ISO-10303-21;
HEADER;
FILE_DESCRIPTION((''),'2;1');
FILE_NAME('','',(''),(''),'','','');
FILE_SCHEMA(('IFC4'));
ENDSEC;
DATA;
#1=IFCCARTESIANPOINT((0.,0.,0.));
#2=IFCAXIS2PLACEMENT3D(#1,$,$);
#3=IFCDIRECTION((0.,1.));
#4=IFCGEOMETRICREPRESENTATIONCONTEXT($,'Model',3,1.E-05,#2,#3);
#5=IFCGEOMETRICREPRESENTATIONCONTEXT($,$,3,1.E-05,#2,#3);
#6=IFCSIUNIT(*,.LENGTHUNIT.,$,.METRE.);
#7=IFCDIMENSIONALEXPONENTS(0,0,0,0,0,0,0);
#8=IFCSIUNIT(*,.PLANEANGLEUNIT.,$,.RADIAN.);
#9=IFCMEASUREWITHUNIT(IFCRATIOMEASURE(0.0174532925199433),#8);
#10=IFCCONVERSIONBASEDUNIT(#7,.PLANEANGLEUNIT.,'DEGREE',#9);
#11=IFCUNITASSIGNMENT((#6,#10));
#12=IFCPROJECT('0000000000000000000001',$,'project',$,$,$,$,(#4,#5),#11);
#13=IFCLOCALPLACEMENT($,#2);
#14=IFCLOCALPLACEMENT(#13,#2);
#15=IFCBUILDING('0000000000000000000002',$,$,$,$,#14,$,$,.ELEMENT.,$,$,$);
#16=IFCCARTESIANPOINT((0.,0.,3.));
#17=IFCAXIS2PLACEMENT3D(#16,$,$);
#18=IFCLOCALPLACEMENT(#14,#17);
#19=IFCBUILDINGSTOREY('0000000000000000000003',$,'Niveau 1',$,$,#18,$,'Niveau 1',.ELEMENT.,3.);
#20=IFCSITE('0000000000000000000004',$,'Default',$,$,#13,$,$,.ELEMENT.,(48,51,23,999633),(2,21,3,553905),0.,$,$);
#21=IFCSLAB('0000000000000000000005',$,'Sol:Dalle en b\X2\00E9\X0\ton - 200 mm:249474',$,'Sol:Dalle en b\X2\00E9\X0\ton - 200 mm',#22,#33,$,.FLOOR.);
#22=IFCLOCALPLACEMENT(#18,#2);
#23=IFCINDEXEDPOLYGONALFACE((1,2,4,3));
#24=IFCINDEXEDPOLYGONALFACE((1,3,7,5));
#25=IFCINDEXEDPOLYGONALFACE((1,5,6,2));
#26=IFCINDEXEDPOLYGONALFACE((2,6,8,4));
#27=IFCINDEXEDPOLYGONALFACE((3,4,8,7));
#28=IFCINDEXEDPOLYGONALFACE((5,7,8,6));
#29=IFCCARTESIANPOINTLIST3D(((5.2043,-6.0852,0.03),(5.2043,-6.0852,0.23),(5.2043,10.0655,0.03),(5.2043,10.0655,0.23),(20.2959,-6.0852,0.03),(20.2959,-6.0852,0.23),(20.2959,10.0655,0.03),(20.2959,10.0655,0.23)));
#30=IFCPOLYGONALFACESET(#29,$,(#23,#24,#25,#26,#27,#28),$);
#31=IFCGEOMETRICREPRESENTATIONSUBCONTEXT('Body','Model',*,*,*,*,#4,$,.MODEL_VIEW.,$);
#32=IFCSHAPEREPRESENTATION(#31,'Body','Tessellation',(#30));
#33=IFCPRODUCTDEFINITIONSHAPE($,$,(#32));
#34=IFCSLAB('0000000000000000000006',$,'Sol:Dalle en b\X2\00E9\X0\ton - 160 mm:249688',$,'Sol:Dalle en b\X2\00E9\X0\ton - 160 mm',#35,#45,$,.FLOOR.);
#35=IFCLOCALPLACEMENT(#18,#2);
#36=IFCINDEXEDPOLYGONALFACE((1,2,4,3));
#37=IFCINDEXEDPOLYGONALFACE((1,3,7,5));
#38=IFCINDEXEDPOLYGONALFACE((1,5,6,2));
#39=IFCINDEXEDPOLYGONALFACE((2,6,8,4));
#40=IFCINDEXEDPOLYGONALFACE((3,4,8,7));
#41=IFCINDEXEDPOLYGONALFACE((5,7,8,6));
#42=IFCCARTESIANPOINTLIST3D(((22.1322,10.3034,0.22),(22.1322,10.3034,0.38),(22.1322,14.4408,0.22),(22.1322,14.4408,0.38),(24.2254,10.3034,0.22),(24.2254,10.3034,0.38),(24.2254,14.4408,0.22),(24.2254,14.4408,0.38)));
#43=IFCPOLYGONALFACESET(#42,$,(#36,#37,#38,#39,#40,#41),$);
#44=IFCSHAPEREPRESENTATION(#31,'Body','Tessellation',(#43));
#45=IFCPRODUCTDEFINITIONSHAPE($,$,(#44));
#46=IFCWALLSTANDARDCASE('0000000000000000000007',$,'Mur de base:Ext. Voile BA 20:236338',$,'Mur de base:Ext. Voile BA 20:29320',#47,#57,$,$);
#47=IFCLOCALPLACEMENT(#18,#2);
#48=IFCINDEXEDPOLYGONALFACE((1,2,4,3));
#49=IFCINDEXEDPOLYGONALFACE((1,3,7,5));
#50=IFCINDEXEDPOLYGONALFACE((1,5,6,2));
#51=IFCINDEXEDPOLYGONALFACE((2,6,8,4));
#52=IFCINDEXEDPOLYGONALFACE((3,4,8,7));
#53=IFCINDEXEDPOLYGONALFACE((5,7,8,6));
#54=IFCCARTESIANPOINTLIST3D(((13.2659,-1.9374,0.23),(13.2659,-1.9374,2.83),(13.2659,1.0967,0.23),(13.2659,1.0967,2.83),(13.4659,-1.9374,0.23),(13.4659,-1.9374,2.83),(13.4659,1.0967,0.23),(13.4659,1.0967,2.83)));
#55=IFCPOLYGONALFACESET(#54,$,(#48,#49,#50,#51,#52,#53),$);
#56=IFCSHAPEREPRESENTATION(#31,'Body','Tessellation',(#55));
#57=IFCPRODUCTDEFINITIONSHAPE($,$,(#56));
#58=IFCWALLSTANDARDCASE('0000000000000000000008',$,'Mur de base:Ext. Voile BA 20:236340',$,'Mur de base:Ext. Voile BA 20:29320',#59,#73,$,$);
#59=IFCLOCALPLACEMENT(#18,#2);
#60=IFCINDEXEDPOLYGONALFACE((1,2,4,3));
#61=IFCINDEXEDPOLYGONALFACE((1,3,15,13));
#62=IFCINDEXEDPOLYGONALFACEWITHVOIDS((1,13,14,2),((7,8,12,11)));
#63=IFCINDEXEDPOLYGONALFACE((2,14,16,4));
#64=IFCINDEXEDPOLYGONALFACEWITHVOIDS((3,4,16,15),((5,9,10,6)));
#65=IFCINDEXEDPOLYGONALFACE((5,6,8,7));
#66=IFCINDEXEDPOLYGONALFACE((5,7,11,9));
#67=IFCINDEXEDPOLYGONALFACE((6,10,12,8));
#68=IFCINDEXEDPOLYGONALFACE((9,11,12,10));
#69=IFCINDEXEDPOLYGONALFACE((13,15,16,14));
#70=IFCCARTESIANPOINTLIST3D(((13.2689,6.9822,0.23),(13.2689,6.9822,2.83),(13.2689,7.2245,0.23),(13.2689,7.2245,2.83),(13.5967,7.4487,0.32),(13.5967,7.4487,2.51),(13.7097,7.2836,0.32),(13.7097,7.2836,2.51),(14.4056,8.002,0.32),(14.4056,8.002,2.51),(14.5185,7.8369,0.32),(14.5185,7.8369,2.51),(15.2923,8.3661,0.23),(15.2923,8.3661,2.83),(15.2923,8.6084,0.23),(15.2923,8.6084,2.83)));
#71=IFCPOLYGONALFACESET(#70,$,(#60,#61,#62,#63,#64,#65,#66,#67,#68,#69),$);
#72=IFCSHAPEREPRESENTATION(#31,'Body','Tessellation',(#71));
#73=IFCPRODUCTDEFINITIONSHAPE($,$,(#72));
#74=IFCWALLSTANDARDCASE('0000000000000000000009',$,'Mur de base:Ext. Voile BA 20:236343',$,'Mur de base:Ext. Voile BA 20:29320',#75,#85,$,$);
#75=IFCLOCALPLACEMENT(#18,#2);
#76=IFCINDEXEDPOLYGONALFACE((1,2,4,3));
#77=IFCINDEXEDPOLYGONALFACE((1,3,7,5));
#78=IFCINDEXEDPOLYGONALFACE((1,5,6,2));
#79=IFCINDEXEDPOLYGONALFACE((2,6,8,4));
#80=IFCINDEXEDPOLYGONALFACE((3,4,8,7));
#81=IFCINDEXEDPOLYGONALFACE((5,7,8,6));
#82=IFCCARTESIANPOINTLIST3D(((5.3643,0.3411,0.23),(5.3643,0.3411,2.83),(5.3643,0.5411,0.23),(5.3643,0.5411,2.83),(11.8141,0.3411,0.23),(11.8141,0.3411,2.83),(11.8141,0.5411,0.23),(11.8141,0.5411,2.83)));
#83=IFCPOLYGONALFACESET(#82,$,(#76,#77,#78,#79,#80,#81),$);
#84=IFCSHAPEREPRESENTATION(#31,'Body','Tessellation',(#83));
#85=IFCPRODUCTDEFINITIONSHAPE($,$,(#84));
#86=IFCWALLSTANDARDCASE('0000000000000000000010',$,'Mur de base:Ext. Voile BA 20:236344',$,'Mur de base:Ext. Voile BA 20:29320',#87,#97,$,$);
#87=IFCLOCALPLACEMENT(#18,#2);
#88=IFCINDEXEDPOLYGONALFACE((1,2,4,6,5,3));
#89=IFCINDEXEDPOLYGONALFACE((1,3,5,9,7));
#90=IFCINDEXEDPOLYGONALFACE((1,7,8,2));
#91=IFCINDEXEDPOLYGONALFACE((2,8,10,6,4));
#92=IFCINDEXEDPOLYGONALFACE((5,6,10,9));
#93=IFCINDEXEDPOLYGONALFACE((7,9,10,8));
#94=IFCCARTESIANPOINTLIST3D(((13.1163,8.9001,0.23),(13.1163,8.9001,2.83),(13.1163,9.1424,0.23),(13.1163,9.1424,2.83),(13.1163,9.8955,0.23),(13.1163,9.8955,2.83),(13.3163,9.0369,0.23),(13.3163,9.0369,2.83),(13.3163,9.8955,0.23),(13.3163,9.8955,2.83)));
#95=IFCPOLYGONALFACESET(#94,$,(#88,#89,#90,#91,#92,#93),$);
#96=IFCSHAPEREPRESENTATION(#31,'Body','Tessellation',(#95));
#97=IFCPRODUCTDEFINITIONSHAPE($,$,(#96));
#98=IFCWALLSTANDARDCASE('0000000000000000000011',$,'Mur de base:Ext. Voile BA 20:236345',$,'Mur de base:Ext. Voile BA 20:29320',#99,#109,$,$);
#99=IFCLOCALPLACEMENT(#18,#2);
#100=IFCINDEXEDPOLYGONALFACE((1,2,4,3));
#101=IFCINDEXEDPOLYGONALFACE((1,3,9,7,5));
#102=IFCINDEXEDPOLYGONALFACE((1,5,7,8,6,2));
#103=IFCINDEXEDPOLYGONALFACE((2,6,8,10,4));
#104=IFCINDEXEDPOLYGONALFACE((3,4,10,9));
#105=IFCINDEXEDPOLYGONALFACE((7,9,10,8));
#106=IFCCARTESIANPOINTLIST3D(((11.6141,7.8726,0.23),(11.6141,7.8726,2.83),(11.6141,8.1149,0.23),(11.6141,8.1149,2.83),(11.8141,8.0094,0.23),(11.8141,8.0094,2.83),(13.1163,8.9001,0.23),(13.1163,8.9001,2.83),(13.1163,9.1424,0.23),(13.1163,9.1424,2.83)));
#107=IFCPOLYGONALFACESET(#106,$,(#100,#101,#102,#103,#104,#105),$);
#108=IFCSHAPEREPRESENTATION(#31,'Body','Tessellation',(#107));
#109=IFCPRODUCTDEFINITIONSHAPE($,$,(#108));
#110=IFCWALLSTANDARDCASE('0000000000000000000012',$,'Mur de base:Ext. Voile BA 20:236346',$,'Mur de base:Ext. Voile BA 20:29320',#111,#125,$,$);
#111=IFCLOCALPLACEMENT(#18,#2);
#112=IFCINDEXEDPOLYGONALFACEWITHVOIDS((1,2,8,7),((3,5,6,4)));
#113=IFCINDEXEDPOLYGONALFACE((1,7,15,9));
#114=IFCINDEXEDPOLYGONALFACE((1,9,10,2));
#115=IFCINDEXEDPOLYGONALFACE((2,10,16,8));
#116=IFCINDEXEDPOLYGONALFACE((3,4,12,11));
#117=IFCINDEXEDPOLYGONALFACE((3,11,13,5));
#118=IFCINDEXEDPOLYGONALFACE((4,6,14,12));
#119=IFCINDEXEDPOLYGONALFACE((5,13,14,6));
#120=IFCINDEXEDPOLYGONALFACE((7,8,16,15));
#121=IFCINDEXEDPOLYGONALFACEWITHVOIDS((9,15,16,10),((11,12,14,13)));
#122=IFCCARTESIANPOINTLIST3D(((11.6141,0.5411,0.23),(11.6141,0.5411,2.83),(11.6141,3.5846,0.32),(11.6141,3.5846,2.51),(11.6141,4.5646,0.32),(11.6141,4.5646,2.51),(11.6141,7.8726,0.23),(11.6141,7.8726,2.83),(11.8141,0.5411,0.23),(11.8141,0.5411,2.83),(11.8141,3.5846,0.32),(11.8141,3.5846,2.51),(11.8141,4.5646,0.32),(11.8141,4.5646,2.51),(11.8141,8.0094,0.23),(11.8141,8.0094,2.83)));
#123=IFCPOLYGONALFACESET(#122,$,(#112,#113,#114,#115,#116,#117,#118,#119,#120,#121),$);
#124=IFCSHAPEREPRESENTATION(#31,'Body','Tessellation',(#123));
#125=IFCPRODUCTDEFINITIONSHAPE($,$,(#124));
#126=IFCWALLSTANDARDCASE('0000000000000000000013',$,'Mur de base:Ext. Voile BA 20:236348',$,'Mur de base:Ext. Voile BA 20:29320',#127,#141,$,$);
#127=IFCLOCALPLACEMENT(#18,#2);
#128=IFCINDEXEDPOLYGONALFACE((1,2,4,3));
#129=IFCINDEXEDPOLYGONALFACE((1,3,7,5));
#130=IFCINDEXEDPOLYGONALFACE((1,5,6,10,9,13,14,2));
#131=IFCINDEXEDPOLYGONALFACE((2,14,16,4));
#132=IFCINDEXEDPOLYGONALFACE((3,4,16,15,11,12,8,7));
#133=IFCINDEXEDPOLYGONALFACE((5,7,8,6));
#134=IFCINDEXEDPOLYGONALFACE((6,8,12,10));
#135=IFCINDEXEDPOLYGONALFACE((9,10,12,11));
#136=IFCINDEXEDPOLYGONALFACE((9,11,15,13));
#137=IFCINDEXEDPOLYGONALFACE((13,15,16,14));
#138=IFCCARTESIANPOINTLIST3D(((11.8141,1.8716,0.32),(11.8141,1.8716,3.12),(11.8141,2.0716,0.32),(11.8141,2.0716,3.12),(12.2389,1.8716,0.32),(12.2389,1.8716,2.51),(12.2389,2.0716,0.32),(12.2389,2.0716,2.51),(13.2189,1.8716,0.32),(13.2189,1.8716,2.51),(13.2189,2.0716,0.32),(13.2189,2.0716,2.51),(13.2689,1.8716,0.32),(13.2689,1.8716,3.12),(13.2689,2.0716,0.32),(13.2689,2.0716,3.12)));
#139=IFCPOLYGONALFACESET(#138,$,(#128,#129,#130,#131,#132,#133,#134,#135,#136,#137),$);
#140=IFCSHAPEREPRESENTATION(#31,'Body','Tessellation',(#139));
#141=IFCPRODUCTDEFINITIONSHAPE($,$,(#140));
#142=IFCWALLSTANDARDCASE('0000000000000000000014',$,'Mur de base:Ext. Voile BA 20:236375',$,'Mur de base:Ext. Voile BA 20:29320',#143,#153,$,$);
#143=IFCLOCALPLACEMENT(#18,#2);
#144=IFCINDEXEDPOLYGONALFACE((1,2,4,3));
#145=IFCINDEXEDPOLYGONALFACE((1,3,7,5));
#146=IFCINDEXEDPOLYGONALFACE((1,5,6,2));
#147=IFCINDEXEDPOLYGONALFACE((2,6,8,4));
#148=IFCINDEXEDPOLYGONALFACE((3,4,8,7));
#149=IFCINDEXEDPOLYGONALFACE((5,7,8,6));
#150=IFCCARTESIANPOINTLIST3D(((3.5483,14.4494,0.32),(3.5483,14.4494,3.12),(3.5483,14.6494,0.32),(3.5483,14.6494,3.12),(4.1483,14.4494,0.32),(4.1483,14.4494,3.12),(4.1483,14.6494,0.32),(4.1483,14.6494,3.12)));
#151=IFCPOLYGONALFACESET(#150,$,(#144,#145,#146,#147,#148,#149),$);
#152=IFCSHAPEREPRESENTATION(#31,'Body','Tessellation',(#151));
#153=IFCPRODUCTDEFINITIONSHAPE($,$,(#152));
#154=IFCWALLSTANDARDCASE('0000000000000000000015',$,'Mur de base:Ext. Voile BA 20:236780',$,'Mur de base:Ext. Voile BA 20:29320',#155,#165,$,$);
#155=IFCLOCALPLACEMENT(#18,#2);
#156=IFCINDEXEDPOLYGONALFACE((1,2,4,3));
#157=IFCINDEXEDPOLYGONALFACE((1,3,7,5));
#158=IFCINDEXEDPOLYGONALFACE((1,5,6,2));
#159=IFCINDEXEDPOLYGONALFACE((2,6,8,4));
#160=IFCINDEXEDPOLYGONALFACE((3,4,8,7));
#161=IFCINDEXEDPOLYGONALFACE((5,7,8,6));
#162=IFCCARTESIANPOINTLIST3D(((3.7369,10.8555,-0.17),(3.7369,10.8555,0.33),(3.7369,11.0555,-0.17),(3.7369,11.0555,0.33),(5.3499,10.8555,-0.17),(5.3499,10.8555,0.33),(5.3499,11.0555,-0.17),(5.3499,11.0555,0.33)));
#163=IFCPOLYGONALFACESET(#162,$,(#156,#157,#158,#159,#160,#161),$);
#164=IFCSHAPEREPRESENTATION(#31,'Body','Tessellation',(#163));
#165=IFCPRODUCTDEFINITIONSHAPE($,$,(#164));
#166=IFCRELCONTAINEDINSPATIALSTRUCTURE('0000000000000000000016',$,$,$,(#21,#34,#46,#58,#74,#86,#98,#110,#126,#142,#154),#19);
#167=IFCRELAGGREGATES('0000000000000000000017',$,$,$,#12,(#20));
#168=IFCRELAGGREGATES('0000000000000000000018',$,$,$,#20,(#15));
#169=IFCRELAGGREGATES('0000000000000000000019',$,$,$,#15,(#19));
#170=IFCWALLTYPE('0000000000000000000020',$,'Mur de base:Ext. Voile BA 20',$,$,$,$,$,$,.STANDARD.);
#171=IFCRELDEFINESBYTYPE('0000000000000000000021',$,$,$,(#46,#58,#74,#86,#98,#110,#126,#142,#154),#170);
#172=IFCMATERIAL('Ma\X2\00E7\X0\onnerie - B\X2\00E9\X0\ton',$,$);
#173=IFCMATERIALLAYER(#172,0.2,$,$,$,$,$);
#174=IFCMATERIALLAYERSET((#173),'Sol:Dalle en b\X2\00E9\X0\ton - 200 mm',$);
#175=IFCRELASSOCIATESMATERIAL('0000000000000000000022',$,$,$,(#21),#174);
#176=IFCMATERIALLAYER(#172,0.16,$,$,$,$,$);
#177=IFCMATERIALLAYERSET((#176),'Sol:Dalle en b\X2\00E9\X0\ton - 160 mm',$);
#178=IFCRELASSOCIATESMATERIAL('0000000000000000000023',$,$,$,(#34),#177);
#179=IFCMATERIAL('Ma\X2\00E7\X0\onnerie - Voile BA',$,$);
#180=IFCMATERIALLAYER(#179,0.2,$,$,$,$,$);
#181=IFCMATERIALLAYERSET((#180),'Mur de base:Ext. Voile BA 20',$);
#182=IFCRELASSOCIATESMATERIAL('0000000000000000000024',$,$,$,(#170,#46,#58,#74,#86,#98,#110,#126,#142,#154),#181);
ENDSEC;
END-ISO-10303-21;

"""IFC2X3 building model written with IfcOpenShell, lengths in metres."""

from ifc_helpers import new_model, entity, si_unit, converted_unit, direction, frame, frame_2d, origin, origin_2d_with_axis, place, context, subcontext, project, spatial, polyline, rectangle, outline, extrude, material, layer, layer_set, layer_usage, type_object, element, save


model = new_model("IFC2X3")

# Units and contexts
model_context = context("Model", 3, precision=1e-05, world=origin(), true_north=direction((0.0, 1.0)))
context_of_model = context(None, 3, precision=1e-05, world=origin(), true_north=direction((0.0, 1.0)))
body_context = subcontext(model_context, "Body", "Model", "MODEL_VIEW")
ifc_project = project(units=[si_unit("LENGTHUNIT", "METRE"), converted_unit("PLANEANGLEUNIT", "DEGREE", entity("IfcRatioMeasure", 0.0174532925199433), si_unit("PLANEANGLEUNIT", "RADIAN"), dimensions=[0, 0, 0, 0, 0, 0, 0])], contexts=[model_context, context_of_model])

# Site, building, storey
site_placement = place(None, origin())
site = spatial("IfcSite", under=ifc_project, at=site_placement, Name="Default", CompositionType="ELEMENT", RefLatitude=(48, 51, 23, 999633), RefLongitude=(2, 21, 3, 553905), RefElevation=0.0)
building_placement = place(site_placement, origin())
building = spatial("IfcBuilding", under=site, at=building_placement, CompositionType="ELEMENT")
storey_placement = place(building_placement, frame((0.0, 0.0, 3.0)))
storey = spatial("IfcBuildingStorey", under=building, at=storey_placement, Name="Niveau 1", LongName="Niveau 1", CompositionType="ELEMENT", Elevation=3.0)

# Shared definitions
ifc_material_1 = material(Name="Maçonnerie - Béton")
ifc_layer_1 = layer(ifc_material_1, 0.2)
ifc_layer_set_1 = layer_set([ifc_layer_1], Name="Sol:Dalle en béton - 200 mm")

# Slabs
ifc_layer_usage_1 = layer_usage(ifc_layer_set_1, "AXIS3", "POSITIVE", 0.0)
slab_1_placement = place(storey_placement, origin())
element("IfcSlab", 1, at=slab_1_placement, inside=storey, material=ifc_layer_usage_1, Name="Sol:Dalle en béton - 200 mm:249474", ObjectType="Sol:Dalle en béton - 200 mm", PredefinedType="FLOOR", context=body_context, shape_type="SweptSolid", body=[
    extrude(rectangle(XDim=16.1506, YDim=15.0917, at=frame_2d((0.0, 0.0), x_axis=(1.0, 0.0))), frame((12.7501, 1.9902, 0.23), z_axis=(0.0, 0.0, -1.0), x_axis=(0.0, 1.0, 0.0)), (0.0, 0.0, 1.0), 0.2),
])
ifc_layer_2 = layer(ifc_material_1, 0.16)
ifc_layer_set_2 = layer_set([ifc_layer_2], Name="Sol:Dalle en béton - 160 mm")
ifc_layer_usage_2 = layer_usage(ifc_layer_set_2, "AXIS3", "POSITIVE", 0.0)
slab_2_placement = place(storey_placement, origin())
element("IfcSlab", 2, at=slab_2_placement, inside=storey, material=ifc_layer_usage_2, Name="Sol:Dalle en béton - 160 mm:249688", ObjectType="Sol:Dalle en béton - 160 mm", PredefinedType="FLOOR", context=body_context, shape_type="SweptSolid", body=[
    extrude(rectangle(XDim=4.1374, YDim=2.0931, at=frame_2d((0.0, 0.0), x_axis=(1.0, 0.0))), frame((23.1788, 12.3721, 0.38), z_axis=(0.0, 0.0, -1.0), x_axis=(0.0, 1.0, 0.0)), (0.0, 0.0, 1.0), 0.16),
])

# Wall
ifc_material_2 = material(Name="Maçonnerie - Voile BA")
ifc_layer_3 = layer(ifc_material_2, 0.2)
ifc_layer_set_3 = layer_set([ifc_layer_3], Name="Mur de base:Ext. Voile BA 20")
ifc_layer_usage_3 = layer_usage(ifc_layer_set_3, "AXIS2", "NEGATIVE", 0.1)
wall_type_1 = type_object("IfcWallType", Name="Mur de base:Ext. Voile BA 20", PredefinedType="STANDARD", material=ifc_layer_set_3)
wall_1_placement = place(storey_placement, frame((13.3659, -1.9374, 0.23), z_axis=(0.0, 0.0, 1.0), x_axis=(0.0, 1.0, 0.0)))
element("IfcWallStandardCase", 3, at=wall_1_placement, inside=storey, type_object=wall_type_1, material=ifc_layer_usage_3, Name="Mur de base:Ext. Voile BA 20:236338", ObjectType="Mur de base:Ext. Voile BA 20:29320", context=body_context, shape_type="SweptSolid", body=[
    extrude(rectangle(XDim=3.0341, YDim=0.2, at=frame_2d((1.517, 0.0), x_axis=(-1.0, 0.0))), origin(), (0.0, 0.0, 1.0), 2.6),
])

# Wall, opening
ifc_layer_usage_4 = layer_usage(ifc_layer_set_3, "AXIS2", "NEGATIVE", 0.1)
wall_2_placement = place(storey_placement, frame((13.2125, 7.0647, 0.23), z_axis=(0.0, 0.0, 1.0), x_axis=(0.825388, 0.564565, 0.0)))
wall_2 = element("IfcWallStandardCase", 4, at=wall_2_placement, inside=storey, type_object=wall_type_1, material=ifc_layer_usage_4, Name="Mur de base:Ext. Voile BA 20:236340", ObjectType="Mur de base:Ext. Voile BA 20:29320", context=body_context, shape_type="SweptSolid", body=[
    extrude(outline(polyline([(2.4514, -0.1), (2.5882, 0.1), (2.3458, 0.1), (0.1368, 0.1), (0.0, -0.1), (0.2423, -0.1), (2.4514, -0.1)])), origin(), (0.0, 0.0, 1.0), 2.6),
])
opening_1_placement = place(wall_2_placement, origin())
element("IfcOpeningElement", 5, at=opening_1_placement, cuts=wall_2, ObjectType="Opening", context=body_context, shape_type="SweptSolid", body=[
    extrude(rectangle(XDim=2.19, YDim=0.98, at=frame_2d((0.0, 0.0), x_axis=(1.0, 0.0))), frame((1.024, -0.1, 1.185), z_axis=(0.0, 1.0, 0.0), x_axis=(0.0, 0.0, -1.0)), (0.0, 0.0, 1.0), 0.2),
])

# Walls
ifc_layer_usage_5 = layer_usage(ifc_layer_set_3, "AXIS2", "NEGATIVE", 0.1)
wall_3_placement = place(storey_placement, frame((5.3643, 0.4411, 0.23)))
element("IfcWallStandardCase", 6, at=wall_3_placement, inside=storey, type_object=wall_type_1, material=ifc_layer_usage_5, Name="Mur de base:Ext. Voile BA 20:236343", ObjectType="Mur de base:Ext. Voile BA 20:29320", context=body_context, shape_type="SweptSolid", body=[
    extrude(rectangle(XDim=6.4498, YDim=0.2, at=frame_2d((3.2249, 0.0), x_axis=(-1.0, 0.0))), origin(), (0.0, 0.0, 1.0), 2.6),
])
ifc_layer_usage_6 = layer_usage(ifc_layer_set_3, "AXIS2", "NEGATIVE", 0.1)
wall_4_placement = place(storey_placement, frame((13.2163, 9.8955, 0.23), z_axis=(0.0, 0.0, 1.0), x_axis=(0.0, -1.0, 0.0)))
element("IfcWallStandardCase", 7, at=wall_4_placement, inside=storey, type_object=wall_type_1, material=ifc_layer_usage_6, Name="Mur de base:Ext. Voile BA 20:236344", ObjectType="Mur de base:Ext. Voile BA 20:29320", context=body_context, shape_type="SweptSolid", body=[
    extrude(outline(polyline([(0.9954, -0.1), (0.8586, 0.1), (0.0, 0.1), (0.0, -0.1), (0.7531, -0.1), (0.9954, -0.1)])), origin(), (0.0, 0.0, 1.0), 2.6),
])
ifc_layer_usage_7 = layer_usage(ifc_layer_set_3, "AXIS2", "NEGATIVE", 0.1)
wall_5_placement = place(storey_placement, frame((13.1727, 9.0598, 0.23), z_axis=(0.0, 0.0, 1.0), x_axis=(-0.825388, -0.564565, 0.0)))
element("IfcWallStandardCase", 8, at=wall_5_placement, inside=storey, type_object=wall_type_1, material=ifc_layer_usage_7, Name="Mur de base:Ext. Voile BA 20:236345", ObjectType="Mur de base:Ext. Voile BA 20:29320", context=body_context, shape_type="SweptSolid", body=[
    extrude(outline(polyline([(1.82, -0.1), (1.9568, 0.1), (1.7145, 0.1), (0.1368, 0.1), (0.0, -0.1), (1.82, -0.1)])), origin(), (0.0, 0.0, 1.0), 2.6),
])

# Walls, openings
ifc_layer_usage_8 = layer_usage(ifc_layer_set_3, "AXIS2", "NEGATIVE", 0.1)
wall_6_placement = place(storey_placement, frame((11.7141, 8.0094, 0.23), z_axis=(0.0, 0.0, 1.0), x_axis=(0.0, -1.0, 0.0)))
wall_6 = element("IfcWallStandardCase", 9, at=wall_6_placement, inside=storey, type_object=wall_type_1, material=ifc_layer_usage_8, Name="Mur de base:Ext. Voile BA 20:236346", ObjectType="Mur de base:Ext. Voile BA 20:29320", context=body_context, shape_type="SweptSolid", body=[
    extrude(outline(polyline([(7.4682, -0.1), (7.4682, 0.1), (0.0, 0.1), (0.1368, -0.1), (7.4682, -0.1)])), origin(), (0.0, 0.0, 1.0), 2.6),
])
opening_2_placement = place(wall_6_placement, origin())
element("IfcOpeningElement", 10, at=opening_2_placement, cuts=wall_6, ObjectType="Opening", context=body_context, shape_type="SweptSolid", body=[
    extrude(rectangle(XDim=2.19, YDim=0.98, at=origin_2d_with_axis()), frame((3.9347, -0.1, 1.185), z_axis=(0.0, 1.0, 0.0), x_axis=(0.0, 0.0, -1.0)), (0.0, 0.0, 1.0), 0.2),
])
ifc_layer_usage_9 = layer_usage(ifc_layer_set_3, "AXIS2", "NEGATIVE", 0.1)
wall_7_placement = place(storey_placement, frame((11.8141, 1.9716, 0.32)))
wall_7 = element("IfcWallStandardCase", 11, at=wall_7_placement, inside=storey, type_object=wall_type_1, material=ifc_layer_usage_9, Name="Mur de base:Ext. Voile BA 20:236348", ObjectType="Mur de base:Ext. Voile BA 20:29320", context=body_context, shape_type="SweptSolid", body=[
    extrude(rectangle(XDim=1.4549, YDim=0.2, at=frame_2d((0.7274, 0.0), x_axis=(-1.0, 0.0))), origin(), (0.0, 0.0, 1.0), 2.8),
])
opening_3_placement = place(wall_7_placement, origin())
element("IfcOpeningElement", 12, at=opening_3_placement, cuts=wall_7, ObjectType="Opening", context=body_context, shape_type="SweptSolid", body=[
    extrude(rectangle(XDim=2.19, YDim=0.98, at=frame_2d((0.0, 0.0), x_axis=(1.0, 0.0))), frame((0.9149, -0.1, 1.095), z_axis=(0.0, 1.0, 0.0), x_axis=(0.0, 0.0, -1.0)), (0.0, 0.0, 1.0), 0.2),
])

# Walls
ifc_layer_usage_10 = layer_usage(ifc_layer_set_3, "AXIS2", "NEGATIVE", 0.1)
wall_8_placement = place(storey_placement, frame((4.1483, 14.5494, 0.32), z_axis=(0.0, 0.0, 1.0), x_axis=(-1.0, 0.0, 0.0)))
element("IfcWallStandardCase", 13, at=wall_8_placement, inside=storey, type_object=wall_type_1, material=ifc_layer_usage_10, Name="Mur de base:Ext. Voile BA 20:236375", ObjectType="Mur de base:Ext. Voile BA 20:29320", context=body_context, shape_type="SweptSolid", body=[
    extrude(rectangle(XDim=0.6, YDim=0.2, at=frame_2d((0.3, 0.0), x_axis=(-1.0, 0.0))), origin(), (0.0, 0.0, 1.0), 2.8),
])
ifc_layer_usage_11 = layer_usage(ifc_layer_set_3, "AXIS2", "NEGATIVE", 0.1)
wall_9_placement = place(storey_placement, frame((3.7369, 10.9555, -0.17)))
element("IfcWallStandardCase", 14, at=wall_9_placement, inside=storey, type_object=wall_type_1, material=ifc_layer_usage_11, Name="Mur de base:Ext. Voile BA 20:236780", ObjectType="Mur de base:Ext. Voile BA 20:29320", context=body_context, shape_type="SweptSolid", body=[
    extrude(rectangle(XDim=1.613, YDim=0.2, at=frame_2d((0.8065, 0.0), x_axis=(-1.0, 0.0))), origin(), (0.0, 0.0, 1.0), 0.5),
])

save(model, "model.ifc")
